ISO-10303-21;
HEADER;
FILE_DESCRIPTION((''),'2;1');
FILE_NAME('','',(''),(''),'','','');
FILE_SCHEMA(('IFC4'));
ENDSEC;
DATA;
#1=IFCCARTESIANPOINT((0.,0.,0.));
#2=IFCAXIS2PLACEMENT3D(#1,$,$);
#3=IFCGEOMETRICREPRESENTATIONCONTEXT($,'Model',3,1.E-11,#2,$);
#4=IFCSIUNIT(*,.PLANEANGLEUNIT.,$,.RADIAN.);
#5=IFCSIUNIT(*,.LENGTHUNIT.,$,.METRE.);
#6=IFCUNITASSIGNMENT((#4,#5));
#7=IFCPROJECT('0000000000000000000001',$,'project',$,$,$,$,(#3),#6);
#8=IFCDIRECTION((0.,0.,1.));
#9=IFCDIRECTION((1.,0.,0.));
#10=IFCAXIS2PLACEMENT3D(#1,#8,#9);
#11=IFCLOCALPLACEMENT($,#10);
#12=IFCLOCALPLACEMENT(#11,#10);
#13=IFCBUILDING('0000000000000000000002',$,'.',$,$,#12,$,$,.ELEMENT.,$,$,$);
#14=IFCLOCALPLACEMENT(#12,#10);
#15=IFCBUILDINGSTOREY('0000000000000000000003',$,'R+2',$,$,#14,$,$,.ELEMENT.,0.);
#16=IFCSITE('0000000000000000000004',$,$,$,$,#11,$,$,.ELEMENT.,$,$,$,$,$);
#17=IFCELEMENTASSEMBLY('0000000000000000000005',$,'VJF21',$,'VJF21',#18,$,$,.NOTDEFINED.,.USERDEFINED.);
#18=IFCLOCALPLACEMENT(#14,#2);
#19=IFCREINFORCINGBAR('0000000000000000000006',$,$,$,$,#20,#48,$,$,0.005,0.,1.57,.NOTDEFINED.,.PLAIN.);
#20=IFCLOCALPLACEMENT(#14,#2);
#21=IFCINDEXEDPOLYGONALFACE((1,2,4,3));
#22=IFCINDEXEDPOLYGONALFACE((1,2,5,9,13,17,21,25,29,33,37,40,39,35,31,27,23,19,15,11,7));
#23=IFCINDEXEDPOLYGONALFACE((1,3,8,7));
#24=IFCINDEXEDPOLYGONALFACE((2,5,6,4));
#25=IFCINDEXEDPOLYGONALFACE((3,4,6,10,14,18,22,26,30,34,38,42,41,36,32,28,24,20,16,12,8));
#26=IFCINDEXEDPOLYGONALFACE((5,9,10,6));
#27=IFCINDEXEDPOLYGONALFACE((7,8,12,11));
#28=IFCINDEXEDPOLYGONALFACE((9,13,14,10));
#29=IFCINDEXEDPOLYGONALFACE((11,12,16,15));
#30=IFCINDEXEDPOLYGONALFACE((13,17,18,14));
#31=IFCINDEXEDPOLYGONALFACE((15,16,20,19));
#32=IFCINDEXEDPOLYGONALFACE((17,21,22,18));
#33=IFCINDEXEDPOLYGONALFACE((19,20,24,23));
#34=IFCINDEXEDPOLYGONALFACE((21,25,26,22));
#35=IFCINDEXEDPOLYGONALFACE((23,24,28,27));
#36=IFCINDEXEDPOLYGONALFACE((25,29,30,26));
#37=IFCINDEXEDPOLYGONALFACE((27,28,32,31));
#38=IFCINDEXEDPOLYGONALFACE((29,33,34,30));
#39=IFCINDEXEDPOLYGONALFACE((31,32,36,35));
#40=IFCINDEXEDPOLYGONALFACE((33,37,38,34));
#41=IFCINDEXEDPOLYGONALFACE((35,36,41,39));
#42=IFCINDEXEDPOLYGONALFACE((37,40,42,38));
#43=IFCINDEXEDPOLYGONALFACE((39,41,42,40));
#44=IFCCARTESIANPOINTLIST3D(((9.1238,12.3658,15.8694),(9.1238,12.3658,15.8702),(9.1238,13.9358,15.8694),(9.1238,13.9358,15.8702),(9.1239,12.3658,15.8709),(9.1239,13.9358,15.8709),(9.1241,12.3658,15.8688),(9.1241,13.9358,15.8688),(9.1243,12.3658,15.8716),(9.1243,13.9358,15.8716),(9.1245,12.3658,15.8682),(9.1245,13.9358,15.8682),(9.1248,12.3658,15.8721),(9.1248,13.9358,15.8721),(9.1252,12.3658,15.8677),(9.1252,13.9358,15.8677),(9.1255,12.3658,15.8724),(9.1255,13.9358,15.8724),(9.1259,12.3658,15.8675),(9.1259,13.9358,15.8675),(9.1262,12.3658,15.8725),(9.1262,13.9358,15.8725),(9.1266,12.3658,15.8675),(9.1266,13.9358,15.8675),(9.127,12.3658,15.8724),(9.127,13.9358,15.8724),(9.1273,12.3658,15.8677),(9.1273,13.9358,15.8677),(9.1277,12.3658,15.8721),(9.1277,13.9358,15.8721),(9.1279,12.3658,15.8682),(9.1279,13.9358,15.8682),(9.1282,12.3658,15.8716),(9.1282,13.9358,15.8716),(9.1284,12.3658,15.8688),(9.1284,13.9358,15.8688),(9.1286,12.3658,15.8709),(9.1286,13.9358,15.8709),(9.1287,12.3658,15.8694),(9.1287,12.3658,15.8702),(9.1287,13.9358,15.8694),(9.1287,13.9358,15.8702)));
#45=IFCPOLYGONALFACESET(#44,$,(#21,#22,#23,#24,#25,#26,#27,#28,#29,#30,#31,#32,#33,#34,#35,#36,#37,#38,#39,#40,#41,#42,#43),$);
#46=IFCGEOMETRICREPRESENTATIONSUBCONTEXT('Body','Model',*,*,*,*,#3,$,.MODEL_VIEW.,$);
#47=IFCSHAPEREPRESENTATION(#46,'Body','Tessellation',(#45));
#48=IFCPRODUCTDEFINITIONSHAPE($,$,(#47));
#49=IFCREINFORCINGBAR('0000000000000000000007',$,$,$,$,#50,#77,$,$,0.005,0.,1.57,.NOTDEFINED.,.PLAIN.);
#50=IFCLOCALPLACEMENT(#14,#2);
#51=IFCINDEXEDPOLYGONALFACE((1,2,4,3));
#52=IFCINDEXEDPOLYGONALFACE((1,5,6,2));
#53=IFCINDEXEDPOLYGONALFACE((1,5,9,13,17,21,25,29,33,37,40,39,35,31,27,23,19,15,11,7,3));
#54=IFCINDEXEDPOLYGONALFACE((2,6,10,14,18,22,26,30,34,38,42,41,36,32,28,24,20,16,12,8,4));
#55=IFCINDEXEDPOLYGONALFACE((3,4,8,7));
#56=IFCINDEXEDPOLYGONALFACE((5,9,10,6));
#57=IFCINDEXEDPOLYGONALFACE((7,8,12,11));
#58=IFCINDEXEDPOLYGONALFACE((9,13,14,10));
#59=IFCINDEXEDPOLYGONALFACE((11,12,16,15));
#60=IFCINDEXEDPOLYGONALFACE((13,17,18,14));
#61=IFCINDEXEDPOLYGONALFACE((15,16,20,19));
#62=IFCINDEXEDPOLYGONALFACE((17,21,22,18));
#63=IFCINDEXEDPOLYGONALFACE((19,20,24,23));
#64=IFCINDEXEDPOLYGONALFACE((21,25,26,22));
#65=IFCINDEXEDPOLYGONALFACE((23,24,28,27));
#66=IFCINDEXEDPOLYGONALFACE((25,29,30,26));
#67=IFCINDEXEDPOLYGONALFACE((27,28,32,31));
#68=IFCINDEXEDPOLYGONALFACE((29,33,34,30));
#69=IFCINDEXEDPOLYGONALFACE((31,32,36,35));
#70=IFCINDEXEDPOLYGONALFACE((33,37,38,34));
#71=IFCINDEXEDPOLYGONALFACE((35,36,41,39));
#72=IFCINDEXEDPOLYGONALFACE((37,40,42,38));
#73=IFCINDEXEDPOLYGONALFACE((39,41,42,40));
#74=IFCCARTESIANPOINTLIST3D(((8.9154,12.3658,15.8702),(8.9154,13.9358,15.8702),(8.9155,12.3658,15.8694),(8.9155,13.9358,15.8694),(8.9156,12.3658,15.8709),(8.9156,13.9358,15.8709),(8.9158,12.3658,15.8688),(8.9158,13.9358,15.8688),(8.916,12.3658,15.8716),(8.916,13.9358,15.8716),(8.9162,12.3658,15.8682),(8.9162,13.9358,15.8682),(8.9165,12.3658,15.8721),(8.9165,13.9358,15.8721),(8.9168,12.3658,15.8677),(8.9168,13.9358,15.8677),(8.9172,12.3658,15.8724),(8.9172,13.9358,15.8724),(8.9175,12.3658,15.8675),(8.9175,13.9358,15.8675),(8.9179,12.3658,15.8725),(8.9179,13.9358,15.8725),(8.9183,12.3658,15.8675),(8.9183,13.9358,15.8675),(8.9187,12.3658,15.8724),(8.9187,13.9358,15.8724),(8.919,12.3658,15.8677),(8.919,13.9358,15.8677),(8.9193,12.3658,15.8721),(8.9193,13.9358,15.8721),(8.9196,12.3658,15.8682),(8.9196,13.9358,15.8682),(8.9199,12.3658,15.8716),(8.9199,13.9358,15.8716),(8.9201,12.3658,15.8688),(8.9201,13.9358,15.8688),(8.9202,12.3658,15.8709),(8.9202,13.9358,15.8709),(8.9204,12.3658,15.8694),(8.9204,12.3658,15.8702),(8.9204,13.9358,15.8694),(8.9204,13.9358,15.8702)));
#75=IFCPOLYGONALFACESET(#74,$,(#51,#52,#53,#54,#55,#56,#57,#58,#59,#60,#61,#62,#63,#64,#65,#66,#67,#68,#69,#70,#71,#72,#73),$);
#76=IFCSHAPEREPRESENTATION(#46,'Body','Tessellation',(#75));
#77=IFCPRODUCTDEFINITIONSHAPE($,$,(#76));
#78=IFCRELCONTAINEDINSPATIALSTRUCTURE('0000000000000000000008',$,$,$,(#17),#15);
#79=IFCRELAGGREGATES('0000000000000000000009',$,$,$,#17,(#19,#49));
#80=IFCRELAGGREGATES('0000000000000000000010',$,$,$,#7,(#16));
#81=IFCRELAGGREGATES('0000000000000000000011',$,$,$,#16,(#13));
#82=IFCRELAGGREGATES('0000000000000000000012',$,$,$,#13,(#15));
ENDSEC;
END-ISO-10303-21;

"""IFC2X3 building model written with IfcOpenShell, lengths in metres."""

from ifc_helpers import new_model, entity, si_unit, origin, origin_with_axes, place, context, subcontext, project, spatial, shape, element, aggregate, save


model = new_model("IFC2X3")

# Units and contexts
model_context = context("Model", 3, precision=1e-11, world=origin())
body_context = subcontext(model_context, "Body", "Model", "MODEL_VIEW")
ifc_project = project(units=[si_unit("PLANEANGLEUNIT", "RADIAN"), si_unit("LENGTHUNIT", "METRE")], contexts=[model_context])

# Site, building, storey
site_placement = place(None, origin_with_axes())
site = spatial("IfcSite", under=ifc_project, at=site_placement, CompositionType="ELEMENT")
building_placement = place(site_placement, origin_with_axes())
building = spatial("IfcBuilding", under=site, at=building_placement, Name=".", CompositionType="ELEMENT")
storey_placement = place(building_placement, origin_with_axes())
storey = spatial("IfcBuildingStorey", under=building, at=storey_placement, Name="R+2", CompositionType="ELEMENT", Elevation=0.0)

# Element assembly, reinforcing bars
assembly_1_placement = place(storey_placement, origin_with_axes())
assembly_1 = element("IfcElementAssembly", 1, at=assembly_1_placement, inside=storey, Name="VJF21", ObjectType="VJF21", AssemblyPlace="NOTDEFINED", PredefinedType="USERDEFINED")
reinforcing_bar_1_placement = place(assembly_1_placement, origin_with_axes())
reinforcing_bar_1 = element("IfcReinforcingBar", 2, at=reinforcing_bar_1_placement, BarLength=1.57, BarRole="NOTDEFINED", BarSurface="PLAIN", CrossSectionArea=0.0, NominalDiameter=0.005, shapes=[
    shape(body_context, "Body", "AdvancedSweptSolid", [entity("IfcSweptDiskSolid", entity("IfcPolyline", [entity("IfcCartesianPoint", [9.1262, 12.3658, 15.87]), entity("IfcCartesianPoint", [9.1262, 13.9358, 15.87])]), 0.0025, None, 0.0, 1.57)]),
    shape(body_context, "Body", "AdvancedSweptSolid", [entity("IfcSweptDiskSolid", entity("IfcPolyline", [entity("IfcCartesianPoint", [9.1262, 12.3658, 15.87]), entity("IfcCartesianPoint", [9.1262, 13.9358, 15.87])]), 0.0025, None, 0.0, 1.57)]),
])
reinforcing_bar_2_placement = place(assembly_1_placement, origin_with_axes())
reinforcing_bar_2 = element("IfcReinforcingBar", 3, at=reinforcing_bar_2_placement, BarLength=1.57, BarRole="NOTDEFINED", BarSurface="PLAIN", CrossSectionArea=0.0, NominalDiameter=0.005, shapes=[
    shape(body_context, "Body", "AdvancedSweptSolid", [entity("IfcSweptDiskSolid", entity("IfcPolyline", [entity("IfcCartesianPoint", [8.9179, 12.3658, 15.87]), entity("IfcCartesianPoint", [8.9179, 13.9358, 15.87])]), 0.0025, None, 0.0, 1.57)]),
    shape(body_context, "Body", "AdvancedSweptSolid", [entity("IfcSweptDiskSolid", entity("IfcPolyline", [entity("IfcCartesianPoint", [8.9179, 12.3658, 15.87]), entity("IfcCartesianPoint", [8.9179, 13.9358, 15.87])]), 0.0025, None, 0.0, 1.57)]),
])
aggregate(assembly_1, [reinforcing_bar_1, reinforcing_bar_2])

save(model, "model.ifc")
